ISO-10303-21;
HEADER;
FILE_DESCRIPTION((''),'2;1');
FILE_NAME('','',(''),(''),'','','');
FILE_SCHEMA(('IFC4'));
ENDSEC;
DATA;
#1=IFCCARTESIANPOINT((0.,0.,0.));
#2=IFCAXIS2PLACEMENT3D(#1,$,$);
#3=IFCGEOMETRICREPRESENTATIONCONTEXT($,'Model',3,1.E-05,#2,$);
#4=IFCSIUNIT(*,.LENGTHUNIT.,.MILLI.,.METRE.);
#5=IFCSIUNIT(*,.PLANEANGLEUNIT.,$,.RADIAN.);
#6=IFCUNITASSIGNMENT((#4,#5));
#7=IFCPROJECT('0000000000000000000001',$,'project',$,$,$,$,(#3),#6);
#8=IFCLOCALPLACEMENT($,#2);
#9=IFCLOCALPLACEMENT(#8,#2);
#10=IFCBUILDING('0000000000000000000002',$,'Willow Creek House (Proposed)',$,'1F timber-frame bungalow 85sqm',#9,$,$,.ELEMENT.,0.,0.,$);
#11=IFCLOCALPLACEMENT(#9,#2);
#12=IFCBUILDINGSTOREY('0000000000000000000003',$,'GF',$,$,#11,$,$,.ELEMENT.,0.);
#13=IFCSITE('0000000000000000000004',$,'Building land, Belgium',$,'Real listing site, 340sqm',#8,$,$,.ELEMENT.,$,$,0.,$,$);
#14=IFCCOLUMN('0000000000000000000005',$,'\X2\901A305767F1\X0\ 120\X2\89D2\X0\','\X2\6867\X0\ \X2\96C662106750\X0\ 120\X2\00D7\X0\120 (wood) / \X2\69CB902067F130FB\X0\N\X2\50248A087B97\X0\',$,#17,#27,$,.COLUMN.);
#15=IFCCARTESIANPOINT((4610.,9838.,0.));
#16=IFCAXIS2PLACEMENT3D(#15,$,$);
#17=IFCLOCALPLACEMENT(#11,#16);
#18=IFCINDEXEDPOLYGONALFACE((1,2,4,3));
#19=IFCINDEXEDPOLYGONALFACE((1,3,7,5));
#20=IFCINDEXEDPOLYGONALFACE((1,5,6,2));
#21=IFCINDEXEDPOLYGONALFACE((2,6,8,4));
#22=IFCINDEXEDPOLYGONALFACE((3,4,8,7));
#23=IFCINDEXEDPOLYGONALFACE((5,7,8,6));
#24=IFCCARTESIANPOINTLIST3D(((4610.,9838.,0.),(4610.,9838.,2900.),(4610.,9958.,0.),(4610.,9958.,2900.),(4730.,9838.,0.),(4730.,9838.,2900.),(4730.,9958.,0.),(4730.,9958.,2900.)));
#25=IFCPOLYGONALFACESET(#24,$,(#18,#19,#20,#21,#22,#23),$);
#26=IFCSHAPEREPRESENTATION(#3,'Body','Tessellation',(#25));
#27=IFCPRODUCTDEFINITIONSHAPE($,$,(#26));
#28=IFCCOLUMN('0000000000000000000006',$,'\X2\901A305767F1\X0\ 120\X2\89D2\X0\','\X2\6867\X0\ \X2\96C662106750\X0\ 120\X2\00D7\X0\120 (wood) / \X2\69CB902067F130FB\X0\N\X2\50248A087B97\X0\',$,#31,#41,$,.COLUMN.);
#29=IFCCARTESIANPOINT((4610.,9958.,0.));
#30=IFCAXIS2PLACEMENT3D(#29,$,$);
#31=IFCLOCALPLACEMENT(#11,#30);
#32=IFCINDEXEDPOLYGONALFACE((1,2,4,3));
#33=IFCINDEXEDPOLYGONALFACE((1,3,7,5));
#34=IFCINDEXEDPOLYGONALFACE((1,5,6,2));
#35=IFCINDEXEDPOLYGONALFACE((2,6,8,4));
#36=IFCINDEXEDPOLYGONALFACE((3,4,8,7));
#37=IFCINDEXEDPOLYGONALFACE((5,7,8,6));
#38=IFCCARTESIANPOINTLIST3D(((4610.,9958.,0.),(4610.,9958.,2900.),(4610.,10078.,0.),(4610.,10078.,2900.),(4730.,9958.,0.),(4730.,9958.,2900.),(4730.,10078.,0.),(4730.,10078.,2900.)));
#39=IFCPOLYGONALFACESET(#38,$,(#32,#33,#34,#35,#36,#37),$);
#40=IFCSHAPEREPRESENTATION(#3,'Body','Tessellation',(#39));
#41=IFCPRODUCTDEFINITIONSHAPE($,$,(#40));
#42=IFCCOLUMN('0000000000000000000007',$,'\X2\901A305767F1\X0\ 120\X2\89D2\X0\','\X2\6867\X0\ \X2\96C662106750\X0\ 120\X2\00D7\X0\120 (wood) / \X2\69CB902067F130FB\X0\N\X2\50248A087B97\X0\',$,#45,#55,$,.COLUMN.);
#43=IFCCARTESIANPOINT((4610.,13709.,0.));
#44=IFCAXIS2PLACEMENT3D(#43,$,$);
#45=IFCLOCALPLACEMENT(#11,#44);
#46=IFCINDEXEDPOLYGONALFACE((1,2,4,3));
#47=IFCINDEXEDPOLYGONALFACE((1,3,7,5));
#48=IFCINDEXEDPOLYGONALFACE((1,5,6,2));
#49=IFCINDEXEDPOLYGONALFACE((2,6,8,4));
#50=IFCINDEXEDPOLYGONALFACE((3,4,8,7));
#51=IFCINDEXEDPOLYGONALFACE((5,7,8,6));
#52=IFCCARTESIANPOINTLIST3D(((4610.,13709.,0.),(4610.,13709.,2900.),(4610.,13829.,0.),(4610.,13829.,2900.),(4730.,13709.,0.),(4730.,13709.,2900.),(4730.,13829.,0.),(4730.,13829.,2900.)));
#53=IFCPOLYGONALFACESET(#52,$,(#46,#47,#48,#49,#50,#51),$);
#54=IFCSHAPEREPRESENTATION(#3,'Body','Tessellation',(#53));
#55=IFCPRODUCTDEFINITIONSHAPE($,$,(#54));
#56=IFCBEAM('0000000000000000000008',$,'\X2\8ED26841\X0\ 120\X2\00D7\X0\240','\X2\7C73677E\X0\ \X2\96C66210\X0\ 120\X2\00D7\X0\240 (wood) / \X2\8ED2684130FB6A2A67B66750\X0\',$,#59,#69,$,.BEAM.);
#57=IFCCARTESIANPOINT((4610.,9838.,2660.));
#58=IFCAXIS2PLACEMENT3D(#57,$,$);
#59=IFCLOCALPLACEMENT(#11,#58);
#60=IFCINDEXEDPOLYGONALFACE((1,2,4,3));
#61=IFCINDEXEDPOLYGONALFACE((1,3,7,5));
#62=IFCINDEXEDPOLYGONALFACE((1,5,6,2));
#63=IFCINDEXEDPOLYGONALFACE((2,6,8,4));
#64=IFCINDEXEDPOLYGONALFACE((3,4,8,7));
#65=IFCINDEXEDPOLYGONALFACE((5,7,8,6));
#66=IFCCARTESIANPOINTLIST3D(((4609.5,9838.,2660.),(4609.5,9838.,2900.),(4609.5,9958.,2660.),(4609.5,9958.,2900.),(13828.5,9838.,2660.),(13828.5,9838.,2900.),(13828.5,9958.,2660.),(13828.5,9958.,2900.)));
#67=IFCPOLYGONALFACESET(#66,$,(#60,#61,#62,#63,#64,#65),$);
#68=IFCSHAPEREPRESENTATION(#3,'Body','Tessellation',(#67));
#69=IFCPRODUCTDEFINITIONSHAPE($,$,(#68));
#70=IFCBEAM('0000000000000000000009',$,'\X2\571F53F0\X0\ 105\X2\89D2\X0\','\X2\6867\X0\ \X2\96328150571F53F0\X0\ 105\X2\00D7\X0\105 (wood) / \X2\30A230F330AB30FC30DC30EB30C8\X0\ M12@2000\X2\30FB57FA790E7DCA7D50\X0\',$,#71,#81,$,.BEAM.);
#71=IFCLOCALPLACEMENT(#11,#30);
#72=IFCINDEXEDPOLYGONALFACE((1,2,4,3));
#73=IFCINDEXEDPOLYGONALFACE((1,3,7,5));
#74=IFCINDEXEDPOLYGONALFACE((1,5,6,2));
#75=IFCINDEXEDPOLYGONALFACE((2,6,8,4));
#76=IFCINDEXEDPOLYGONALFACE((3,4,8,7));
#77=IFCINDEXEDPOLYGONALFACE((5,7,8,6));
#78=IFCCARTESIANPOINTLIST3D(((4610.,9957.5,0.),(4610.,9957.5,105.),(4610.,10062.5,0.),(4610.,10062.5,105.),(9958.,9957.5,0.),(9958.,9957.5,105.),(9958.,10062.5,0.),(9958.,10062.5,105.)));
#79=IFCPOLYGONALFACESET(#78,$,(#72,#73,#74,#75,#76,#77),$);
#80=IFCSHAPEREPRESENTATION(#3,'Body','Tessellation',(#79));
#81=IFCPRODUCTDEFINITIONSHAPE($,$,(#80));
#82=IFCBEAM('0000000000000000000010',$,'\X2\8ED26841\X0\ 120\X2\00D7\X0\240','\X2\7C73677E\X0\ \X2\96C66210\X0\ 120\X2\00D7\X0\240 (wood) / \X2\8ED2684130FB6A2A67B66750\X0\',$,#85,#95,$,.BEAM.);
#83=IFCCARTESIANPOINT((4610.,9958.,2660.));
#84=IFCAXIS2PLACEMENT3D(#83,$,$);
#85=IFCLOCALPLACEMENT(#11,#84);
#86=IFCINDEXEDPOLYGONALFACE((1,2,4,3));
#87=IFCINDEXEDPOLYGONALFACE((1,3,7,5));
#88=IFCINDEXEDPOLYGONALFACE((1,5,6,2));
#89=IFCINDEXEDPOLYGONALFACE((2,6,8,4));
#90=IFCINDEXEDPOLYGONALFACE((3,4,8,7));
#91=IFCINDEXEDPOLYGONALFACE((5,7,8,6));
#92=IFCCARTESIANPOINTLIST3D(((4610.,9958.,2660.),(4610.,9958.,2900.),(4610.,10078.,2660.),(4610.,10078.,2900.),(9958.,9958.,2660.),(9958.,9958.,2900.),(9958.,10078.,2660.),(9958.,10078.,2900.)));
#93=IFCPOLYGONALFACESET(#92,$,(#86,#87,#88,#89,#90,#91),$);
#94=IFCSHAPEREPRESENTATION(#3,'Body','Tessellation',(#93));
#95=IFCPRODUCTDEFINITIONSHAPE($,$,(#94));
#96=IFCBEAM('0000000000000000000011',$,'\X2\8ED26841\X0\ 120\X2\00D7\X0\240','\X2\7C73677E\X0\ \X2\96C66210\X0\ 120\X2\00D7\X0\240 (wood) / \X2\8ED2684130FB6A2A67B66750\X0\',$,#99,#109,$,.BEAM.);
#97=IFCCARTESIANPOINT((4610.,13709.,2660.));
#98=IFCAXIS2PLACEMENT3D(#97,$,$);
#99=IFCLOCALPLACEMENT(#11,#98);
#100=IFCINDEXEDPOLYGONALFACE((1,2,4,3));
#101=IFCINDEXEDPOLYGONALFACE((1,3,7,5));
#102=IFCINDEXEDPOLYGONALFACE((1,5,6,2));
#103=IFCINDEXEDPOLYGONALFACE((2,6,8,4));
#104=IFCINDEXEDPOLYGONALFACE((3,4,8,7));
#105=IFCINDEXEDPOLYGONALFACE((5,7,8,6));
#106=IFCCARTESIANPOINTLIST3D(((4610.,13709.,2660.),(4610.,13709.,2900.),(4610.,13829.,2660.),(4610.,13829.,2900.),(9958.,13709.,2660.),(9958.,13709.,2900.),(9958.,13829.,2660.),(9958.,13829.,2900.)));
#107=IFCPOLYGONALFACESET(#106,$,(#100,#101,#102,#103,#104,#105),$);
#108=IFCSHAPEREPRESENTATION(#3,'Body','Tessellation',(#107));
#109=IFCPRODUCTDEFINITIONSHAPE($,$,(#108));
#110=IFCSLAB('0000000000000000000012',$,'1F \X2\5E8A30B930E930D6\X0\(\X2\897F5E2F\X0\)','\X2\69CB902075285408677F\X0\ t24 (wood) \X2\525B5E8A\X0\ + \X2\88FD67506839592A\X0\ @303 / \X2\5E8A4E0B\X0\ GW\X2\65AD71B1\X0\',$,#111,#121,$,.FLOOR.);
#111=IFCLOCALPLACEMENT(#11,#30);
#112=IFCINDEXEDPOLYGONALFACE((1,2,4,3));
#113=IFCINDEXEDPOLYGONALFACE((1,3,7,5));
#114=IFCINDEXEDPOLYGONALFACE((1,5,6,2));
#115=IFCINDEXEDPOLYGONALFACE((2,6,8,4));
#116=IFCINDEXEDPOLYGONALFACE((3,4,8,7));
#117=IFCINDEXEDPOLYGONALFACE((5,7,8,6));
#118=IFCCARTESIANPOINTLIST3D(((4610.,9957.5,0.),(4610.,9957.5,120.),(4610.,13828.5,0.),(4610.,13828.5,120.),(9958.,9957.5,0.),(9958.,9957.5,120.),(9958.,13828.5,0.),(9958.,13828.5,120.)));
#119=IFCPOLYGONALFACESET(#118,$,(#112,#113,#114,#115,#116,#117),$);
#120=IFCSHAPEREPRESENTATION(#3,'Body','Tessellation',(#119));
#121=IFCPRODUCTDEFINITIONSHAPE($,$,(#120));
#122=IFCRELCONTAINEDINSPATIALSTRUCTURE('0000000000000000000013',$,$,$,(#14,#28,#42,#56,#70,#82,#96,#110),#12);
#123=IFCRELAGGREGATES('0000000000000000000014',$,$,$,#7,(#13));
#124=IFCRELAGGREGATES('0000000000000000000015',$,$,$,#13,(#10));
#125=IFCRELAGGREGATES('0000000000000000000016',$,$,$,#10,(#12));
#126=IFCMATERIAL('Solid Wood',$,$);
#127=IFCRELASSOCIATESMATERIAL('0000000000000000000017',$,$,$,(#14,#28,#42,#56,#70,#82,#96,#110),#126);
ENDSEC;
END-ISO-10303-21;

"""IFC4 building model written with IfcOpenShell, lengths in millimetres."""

from ifc_helpers import new_model, si_unit, frame, frame_2d, origin, place, context, project, spatial, rectangle, extrude, material, element, save


model = new_model("IFC4")

# Units and contexts
model_context = context("Model", 3, precision=1e-05, world=origin())
ifc_project = project(units=[si_unit("LENGTHUNIT", "METRE", prefix="MILLI"), si_unit("PLANEANGLEUNIT", "RADIAN")], contexts=[model_context])

# Site, building, storey
site_placement = place(None, origin())
site = spatial("IfcSite", under=ifc_project, at=site_placement, Name="Building land, Belgium", ObjectType="Real listing site, 340sqm", CompositionType="ELEMENT", RefElevation=0.0)
building_placement = place(site_placement, origin())
building = spatial("IfcBuilding", under=site, at=building_placement, Name="Willow Creek House (Proposed)", ObjectType="1F timber-frame bungalow 85sqm", CompositionType="ELEMENT", ElevationOfRefHeight=0.0, ElevationOfTerrain=0.0)
storey_placement = place(building_placement, origin())
storey = spatial("IfcBuildingStorey", under=building, at=storey_placement, Name="GF", CompositionType="ELEMENT", Elevation=0.0)

# Columns
ifc_material_1 = material(Name="Solid Wood")
column_1_placement = place(storey_placement, frame((4610.0, 9838.0, 0.0)))
element("IfcColumn", 1, at=column_1_placement, inside=storey, material=ifc_material_1, Name="通し柱 120角", Description="桧 集成材 120×120 (wood) / 構造柱・N値計算", PredefinedType="COLUMN", context=model_context, shape_type="SweptSolid", body=[
    extrude(rectangle(XDim=120.0, YDim=120.0, at=frame_2d((60.0, 60.0))), frame((4610.0, 9838.0, 0.0)), (0.0, 0.0, 1.0), 2900.0),
])
column_2_placement = place(storey_placement, frame((4610.0, 9958.0, 0.0)))
element("IfcColumn", 2, at=column_2_placement, inside=storey, material=ifc_material_1, Name="通し柱 120角", Description="桧 集成材 120×120 (wood) / 構造柱・N値計算", PredefinedType="COLUMN", context=model_context, shape_type="SweptSolid", body=[
    extrude(rectangle(XDim=120.0, YDim=120.0, at=frame_2d((60.0, 60.0))), frame((4610.0, 9958.0, 0.0)), (0.0, 0.0, 1.0), 2900.0),
])
column_3_placement = place(storey_placement, frame((4610.0, 13709.0, 0.0)))
element("IfcColumn", 3, at=column_3_placement, inside=storey, material=ifc_material_1, Name="通し柱 120角", Description="桧 集成材 120×120 (wood) / 構造柱・N値計算", PredefinedType="COLUMN", context=model_context, shape_type="SweptSolid", body=[
    extrude(rectangle(XDim=120.0, YDim=120.0, at=frame_2d((60.0, 60.0))), frame((4610.0, 13709.0, 0.0)), (0.0, 0.0, 1.0), 2900.0),
])

# Beams
beam_1_placement = place(storey_placement, frame((4610.0, 9838.0, 2660.0)))
element("IfcBeam", 4, at=beam_1_placement, inside=storey, material=ifc_material_1, Name="軒桁 120×240", Description="米松 集成 120×240 (wood) / 軒桁・横架材", PredefinedType="BEAM", context=model_context, shape_type="SweptSolid", body=[
    extrude(rectangle(XDim=9219.0, YDim=120.0, at=frame_2d((4609.0, 60.0))), frame((4610.0, 9838.0, 2660.0)), (0.0, 0.0, 1.0), 240.0),
])
beam_2_placement = place(storey_placement, frame((4610.0, 9958.0, 0.0)))
element("IfcBeam", 5, at=beam_2_placement, inside=storey, material=ifc_material_1, Name="土台 105角", Description="桧 防腐土台 105×105 (wood) / アンカーボルト M12@2000・基礎緊結", PredefinedType="BEAM", context=model_context, shape_type="SweptSolid", body=[
    extrude(rectangle(XDim=5348.0, YDim=105.0, at=frame_2d((2674.0, 52.0))), frame((4610.0, 9958.0, 0.0)), (0.0, 0.0, 1.0), 105.0),
])
beam_3_placement = place(storey_placement, frame((4610.0, 9958.0, 2660.0)))
element("IfcBeam", 6, at=beam_3_placement, inside=storey, material=ifc_material_1, Name="軒桁 120×240", Description="米松 集成 120×240 (wood) / 軒桁・横架材", PredefinedType="BEAM", context=model_context, shape_type="SweptSolid", body=[
    extrude(rectangle(XDim=5348.0, YDim=120.0, at=frame_2d((2674.0, 60.0))), frame((4610.0, 9958.0, 2660.0)), (0.0, 0.0, 1.0), 240.0),
])
beam_4_placement = place(storey_placement, frame((4610.0, 13709.0, 2660.0)))
element("IfcBeam", 7, at=beam_4_placement, inside=storey, material=ifc_material_1, Name="軒桁 120×240", Description="米松 集成 120×240 (wood) / 軒桁・横架材", PredefinedType="BEAM", context=model_context, shape_type="SweptSolid", body=[
    extrude(rectangle(XDim=5348.0, YDim=120.0, at=frame_2d((2674.0, 60.0))), frame((4610.0, 13709.0, 2660.0)), (0.0, 0.0, 1.0), 240.0),
])

# Slab
slab_placement = place(storey_placement, frame((4610.0, 9958.0, 0.0)))
element("IfcSlab", 8, at=slab_placement, inside=storey, material=ifc_material_1, Name="1F 床スラブ(西帯)", Description="構造用合板 t24 (wood) 剛床 + 製材根太 @303 / 床下 GW断熱", PredefinedType="FLOOR", context=model_context, shape_type="SweptSolid", body=[
    extrude(rectangle(XDim=5348.0, YDim=3871.0, at=frame_2d((2674.0, 1935.0))), frame((4610.0, 9958.0, 0.0)), (0.0, 0.0, 1.0), 120.0),
])

save(model, "model.ifc")
